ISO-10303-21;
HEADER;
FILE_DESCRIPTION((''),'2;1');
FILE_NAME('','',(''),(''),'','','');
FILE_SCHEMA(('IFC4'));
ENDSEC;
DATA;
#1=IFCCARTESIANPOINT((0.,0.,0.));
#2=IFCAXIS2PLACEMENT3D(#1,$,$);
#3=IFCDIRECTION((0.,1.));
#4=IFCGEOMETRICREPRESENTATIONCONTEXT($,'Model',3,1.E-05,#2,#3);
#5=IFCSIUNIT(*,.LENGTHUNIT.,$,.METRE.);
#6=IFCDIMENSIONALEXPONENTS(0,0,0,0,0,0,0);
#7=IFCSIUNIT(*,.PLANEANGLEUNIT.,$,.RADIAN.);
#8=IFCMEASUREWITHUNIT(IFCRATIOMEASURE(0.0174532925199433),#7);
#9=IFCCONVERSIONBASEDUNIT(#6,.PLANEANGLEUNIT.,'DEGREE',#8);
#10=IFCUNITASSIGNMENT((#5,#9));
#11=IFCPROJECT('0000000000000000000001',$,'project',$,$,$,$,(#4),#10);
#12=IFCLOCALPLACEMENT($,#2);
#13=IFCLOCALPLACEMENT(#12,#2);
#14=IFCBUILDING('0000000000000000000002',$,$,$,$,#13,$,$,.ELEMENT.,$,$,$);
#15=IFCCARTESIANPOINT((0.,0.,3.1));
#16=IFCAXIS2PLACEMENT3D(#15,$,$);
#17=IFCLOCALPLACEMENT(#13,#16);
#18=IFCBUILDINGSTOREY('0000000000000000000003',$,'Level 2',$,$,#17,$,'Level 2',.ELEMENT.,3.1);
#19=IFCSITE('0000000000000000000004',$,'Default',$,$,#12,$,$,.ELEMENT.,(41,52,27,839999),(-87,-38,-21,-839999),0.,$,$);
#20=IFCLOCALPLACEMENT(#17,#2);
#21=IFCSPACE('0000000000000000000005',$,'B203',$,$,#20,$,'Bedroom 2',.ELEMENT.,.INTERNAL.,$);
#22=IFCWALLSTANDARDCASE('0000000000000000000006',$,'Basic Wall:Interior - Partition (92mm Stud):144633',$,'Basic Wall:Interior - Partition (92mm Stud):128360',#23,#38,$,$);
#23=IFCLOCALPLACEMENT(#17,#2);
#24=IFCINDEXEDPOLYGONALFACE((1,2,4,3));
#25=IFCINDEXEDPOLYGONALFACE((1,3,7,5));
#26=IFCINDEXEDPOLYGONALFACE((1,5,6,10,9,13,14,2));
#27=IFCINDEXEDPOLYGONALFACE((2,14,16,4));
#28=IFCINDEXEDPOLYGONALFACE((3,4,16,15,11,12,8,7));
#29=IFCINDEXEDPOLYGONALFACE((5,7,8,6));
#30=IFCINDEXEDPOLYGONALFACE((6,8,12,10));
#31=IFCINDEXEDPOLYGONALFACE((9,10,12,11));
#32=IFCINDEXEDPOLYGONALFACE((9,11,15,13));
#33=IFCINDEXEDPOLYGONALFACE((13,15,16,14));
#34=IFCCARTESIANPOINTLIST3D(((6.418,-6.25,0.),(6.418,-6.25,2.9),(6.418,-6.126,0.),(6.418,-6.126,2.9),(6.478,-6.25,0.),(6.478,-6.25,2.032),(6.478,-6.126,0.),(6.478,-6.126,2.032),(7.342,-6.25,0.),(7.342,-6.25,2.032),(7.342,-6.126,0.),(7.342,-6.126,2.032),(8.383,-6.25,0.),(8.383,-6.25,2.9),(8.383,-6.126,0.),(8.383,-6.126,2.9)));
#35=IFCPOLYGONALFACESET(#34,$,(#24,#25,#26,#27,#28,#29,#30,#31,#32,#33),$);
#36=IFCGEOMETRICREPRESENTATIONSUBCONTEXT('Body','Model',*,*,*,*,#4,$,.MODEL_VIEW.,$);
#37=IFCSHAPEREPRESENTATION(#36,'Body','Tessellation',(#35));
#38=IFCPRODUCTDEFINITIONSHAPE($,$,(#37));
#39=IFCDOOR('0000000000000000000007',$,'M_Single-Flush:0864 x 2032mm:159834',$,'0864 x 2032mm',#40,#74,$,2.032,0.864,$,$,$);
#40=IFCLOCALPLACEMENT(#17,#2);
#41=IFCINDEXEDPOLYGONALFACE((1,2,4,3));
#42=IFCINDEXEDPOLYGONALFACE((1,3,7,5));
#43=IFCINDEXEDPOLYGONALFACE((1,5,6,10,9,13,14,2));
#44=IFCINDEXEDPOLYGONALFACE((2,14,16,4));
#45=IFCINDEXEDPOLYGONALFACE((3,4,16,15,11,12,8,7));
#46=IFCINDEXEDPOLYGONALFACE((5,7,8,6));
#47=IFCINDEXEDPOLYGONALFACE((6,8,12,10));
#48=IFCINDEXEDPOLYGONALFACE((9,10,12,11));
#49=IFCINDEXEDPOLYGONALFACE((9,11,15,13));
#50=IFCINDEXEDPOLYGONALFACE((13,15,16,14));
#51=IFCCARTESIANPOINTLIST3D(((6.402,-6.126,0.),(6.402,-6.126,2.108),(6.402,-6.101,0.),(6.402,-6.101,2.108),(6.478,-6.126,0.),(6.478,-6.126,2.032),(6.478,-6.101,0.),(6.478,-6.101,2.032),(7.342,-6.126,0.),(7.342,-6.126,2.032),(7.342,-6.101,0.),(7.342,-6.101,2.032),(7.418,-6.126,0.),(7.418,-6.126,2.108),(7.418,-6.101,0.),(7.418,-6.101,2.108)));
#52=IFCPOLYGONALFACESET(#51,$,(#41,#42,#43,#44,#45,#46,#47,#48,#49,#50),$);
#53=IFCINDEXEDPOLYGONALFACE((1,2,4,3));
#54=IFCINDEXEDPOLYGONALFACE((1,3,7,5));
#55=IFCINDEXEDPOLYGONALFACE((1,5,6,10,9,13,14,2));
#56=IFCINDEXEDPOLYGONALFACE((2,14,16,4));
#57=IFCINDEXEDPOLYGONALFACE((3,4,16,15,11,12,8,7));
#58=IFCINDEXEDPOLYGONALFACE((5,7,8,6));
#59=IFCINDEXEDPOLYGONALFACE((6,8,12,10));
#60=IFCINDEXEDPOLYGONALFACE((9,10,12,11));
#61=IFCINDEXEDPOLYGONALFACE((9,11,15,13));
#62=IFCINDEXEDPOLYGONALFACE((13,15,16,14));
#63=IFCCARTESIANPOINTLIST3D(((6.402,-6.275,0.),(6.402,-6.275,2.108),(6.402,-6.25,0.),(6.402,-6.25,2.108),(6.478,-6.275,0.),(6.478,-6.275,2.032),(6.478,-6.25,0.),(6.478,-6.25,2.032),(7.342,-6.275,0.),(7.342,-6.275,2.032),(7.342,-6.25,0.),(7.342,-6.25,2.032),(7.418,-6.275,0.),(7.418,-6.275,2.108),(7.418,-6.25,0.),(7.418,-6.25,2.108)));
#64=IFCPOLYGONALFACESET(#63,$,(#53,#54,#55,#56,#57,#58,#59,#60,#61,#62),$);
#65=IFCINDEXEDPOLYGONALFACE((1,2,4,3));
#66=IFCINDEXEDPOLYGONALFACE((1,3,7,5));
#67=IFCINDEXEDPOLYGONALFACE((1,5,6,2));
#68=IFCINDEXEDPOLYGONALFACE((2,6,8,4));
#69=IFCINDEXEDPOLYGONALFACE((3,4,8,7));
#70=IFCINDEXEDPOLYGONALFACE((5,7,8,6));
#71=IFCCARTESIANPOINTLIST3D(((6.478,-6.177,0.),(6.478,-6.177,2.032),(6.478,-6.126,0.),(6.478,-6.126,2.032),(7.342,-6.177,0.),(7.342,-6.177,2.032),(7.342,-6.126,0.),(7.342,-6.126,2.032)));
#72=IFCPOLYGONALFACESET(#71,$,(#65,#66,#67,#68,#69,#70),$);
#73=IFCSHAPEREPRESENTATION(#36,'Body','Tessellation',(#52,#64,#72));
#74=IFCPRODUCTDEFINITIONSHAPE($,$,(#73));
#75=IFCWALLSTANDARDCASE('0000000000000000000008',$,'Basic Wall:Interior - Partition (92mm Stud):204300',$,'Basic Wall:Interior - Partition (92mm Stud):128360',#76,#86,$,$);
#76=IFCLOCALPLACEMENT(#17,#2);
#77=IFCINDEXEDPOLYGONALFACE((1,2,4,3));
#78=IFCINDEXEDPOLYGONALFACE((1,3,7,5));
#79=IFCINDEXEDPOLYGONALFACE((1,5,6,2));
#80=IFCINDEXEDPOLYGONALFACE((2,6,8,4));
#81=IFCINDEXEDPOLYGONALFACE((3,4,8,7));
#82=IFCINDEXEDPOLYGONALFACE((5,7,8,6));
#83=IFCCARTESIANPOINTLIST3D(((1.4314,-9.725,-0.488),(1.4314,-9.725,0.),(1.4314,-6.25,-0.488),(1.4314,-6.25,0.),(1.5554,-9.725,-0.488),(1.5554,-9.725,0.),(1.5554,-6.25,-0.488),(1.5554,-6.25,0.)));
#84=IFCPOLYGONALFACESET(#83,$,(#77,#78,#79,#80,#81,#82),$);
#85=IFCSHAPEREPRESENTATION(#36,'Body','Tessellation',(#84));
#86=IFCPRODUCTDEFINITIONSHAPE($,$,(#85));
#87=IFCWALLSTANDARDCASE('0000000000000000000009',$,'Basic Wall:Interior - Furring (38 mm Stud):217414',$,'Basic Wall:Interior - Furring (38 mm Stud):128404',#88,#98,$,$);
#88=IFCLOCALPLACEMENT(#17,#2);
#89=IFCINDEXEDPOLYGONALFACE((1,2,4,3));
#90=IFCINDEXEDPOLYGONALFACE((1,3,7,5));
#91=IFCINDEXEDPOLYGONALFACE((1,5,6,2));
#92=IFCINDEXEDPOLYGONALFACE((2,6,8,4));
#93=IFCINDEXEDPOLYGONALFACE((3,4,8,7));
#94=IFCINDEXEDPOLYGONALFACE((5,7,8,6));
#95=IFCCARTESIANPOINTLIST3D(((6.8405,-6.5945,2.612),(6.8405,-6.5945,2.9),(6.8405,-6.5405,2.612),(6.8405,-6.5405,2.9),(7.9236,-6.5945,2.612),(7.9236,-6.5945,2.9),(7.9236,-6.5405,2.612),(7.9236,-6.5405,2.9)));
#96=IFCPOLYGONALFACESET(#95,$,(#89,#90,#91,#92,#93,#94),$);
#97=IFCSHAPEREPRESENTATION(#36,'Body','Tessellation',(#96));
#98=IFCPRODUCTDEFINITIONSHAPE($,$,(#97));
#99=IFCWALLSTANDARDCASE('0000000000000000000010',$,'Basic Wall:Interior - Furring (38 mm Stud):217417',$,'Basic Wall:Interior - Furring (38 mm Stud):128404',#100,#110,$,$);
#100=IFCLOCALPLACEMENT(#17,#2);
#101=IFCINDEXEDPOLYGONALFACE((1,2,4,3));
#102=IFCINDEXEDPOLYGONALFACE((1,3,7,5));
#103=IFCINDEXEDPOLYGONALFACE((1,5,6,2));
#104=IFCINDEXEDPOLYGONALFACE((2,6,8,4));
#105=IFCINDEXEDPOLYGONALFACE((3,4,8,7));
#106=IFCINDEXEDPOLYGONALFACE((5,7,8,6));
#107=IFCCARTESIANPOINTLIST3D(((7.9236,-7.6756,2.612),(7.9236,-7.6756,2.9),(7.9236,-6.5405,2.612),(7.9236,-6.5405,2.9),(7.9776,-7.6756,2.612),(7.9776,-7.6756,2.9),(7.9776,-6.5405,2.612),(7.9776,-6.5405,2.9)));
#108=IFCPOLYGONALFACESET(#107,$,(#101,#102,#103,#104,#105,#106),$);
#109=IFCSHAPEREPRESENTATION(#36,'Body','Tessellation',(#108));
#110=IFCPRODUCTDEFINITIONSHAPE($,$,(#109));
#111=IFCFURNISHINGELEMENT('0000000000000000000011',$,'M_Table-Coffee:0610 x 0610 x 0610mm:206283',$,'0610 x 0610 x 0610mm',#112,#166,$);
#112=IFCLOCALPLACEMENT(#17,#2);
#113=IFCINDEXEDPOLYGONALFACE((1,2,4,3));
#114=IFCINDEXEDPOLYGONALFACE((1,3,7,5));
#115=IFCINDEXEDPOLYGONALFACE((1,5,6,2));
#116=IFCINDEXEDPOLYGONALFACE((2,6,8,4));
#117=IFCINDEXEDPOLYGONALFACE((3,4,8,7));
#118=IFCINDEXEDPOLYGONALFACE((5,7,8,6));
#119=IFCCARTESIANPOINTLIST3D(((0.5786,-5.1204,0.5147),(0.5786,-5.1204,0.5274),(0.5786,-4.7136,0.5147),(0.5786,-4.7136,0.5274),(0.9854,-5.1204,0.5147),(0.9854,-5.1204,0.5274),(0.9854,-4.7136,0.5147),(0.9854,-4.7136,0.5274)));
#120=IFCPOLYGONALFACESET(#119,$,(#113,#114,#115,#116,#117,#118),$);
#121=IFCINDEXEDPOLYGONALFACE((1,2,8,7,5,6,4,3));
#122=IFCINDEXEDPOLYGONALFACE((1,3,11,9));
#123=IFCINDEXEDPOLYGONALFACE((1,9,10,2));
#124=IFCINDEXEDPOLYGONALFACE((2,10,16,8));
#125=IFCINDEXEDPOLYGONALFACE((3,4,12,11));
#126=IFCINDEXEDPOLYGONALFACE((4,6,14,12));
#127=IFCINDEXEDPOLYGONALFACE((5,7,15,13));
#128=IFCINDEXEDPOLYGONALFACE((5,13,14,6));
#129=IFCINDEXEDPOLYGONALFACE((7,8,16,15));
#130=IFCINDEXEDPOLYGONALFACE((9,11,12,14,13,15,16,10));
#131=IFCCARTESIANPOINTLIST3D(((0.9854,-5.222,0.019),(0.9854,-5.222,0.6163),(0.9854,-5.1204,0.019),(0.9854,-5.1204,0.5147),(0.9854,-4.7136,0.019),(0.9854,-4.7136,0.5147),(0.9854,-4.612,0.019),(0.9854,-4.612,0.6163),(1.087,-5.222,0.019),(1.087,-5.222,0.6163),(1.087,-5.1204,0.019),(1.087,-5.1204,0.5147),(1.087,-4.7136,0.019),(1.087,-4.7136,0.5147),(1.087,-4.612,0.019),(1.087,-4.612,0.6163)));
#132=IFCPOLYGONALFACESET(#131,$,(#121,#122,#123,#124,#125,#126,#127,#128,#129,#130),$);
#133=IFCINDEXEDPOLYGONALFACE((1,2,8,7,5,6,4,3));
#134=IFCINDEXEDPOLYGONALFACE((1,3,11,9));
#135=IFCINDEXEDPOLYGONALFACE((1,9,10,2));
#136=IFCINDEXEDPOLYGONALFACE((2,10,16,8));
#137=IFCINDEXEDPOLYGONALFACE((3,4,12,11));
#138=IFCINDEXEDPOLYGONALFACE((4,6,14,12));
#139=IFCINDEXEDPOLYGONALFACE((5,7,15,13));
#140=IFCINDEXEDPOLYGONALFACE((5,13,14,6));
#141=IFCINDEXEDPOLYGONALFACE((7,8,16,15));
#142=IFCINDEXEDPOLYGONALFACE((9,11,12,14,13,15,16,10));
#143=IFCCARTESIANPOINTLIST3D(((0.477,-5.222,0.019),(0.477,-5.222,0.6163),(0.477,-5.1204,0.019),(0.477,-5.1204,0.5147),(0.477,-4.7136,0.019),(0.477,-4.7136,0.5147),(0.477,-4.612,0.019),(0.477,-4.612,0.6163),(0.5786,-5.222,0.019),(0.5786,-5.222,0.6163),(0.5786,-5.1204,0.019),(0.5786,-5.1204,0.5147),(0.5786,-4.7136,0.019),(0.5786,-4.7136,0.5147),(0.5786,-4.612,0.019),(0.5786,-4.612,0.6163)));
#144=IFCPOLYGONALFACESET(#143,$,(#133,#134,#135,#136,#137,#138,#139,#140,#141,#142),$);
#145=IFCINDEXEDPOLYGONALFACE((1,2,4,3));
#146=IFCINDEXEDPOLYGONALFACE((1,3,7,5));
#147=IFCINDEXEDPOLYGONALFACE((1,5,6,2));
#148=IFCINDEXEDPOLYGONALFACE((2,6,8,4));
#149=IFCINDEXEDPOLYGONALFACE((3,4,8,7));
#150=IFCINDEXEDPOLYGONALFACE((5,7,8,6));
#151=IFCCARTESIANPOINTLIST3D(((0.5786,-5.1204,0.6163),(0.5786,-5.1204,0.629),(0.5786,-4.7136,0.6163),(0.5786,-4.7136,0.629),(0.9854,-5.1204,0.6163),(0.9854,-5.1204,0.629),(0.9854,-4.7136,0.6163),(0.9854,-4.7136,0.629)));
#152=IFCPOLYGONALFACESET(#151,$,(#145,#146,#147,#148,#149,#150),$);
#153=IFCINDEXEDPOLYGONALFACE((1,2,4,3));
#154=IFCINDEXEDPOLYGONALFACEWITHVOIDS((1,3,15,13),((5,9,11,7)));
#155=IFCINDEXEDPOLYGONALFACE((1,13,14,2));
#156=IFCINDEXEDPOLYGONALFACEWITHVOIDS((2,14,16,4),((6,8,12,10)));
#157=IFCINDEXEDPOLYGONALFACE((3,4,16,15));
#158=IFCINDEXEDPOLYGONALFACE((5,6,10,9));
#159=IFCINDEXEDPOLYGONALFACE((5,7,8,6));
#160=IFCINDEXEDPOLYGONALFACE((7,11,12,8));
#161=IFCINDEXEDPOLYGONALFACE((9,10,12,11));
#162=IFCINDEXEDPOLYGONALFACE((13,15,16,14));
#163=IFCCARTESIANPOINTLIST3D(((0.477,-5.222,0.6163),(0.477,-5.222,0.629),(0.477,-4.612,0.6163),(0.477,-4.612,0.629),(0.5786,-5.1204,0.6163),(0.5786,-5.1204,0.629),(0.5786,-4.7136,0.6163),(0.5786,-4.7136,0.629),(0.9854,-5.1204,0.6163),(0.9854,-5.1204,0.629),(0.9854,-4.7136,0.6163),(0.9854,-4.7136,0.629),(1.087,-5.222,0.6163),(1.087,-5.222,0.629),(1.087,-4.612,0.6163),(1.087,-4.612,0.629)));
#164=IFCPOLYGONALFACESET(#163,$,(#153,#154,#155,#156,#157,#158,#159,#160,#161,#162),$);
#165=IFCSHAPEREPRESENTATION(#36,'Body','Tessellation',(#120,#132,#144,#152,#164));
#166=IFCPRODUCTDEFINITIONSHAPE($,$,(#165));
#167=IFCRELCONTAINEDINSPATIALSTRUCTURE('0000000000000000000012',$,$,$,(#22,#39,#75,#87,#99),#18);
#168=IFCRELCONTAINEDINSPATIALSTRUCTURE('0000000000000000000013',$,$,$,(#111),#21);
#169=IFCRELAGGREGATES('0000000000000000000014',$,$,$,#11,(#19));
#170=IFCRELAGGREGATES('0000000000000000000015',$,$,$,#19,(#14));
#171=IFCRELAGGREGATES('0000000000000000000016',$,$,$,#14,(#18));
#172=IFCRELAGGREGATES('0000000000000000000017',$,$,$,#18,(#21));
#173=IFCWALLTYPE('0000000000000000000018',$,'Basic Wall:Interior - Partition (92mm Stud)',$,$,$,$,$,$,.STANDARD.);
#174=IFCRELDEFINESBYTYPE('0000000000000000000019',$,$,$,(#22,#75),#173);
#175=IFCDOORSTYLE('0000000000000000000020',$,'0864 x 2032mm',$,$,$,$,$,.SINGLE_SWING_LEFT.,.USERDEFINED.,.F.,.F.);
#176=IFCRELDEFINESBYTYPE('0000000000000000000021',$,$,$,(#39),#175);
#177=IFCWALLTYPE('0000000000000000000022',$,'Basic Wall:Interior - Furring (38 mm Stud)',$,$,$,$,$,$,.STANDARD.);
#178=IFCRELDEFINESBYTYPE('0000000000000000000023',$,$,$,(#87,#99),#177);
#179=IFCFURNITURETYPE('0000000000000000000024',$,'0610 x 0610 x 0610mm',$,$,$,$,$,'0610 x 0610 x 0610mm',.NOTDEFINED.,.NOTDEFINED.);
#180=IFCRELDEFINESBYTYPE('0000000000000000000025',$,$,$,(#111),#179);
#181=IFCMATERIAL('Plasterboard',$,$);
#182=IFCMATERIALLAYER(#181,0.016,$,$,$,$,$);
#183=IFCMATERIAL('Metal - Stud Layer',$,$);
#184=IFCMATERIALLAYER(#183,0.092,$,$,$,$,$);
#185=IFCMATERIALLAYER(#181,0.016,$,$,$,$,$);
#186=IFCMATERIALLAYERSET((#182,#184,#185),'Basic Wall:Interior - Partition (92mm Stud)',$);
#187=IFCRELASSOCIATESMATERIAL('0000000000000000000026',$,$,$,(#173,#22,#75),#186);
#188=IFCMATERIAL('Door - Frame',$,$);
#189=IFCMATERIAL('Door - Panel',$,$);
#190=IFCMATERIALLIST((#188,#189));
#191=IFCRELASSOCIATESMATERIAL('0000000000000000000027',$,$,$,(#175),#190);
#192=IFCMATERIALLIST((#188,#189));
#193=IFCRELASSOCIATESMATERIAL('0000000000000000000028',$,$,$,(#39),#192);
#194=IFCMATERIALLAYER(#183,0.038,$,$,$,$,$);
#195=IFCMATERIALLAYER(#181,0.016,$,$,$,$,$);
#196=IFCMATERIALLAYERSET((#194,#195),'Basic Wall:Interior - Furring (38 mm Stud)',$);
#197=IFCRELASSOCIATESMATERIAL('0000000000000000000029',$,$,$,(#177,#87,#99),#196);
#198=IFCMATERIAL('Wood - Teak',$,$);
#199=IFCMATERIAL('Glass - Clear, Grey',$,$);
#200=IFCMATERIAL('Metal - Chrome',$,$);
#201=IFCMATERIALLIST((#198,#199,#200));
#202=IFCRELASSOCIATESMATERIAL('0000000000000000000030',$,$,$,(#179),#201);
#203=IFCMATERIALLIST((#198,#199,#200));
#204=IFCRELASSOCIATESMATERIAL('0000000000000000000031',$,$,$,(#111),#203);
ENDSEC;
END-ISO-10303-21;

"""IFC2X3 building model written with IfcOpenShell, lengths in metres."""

from ifc_helpers import new_model, entity, si_unit, converted_unit, direction, frame, frame_2d, origin, origin_2d_with_axis, place, context, subcontext, project, spatial, polyline, rectangle, outline, extrude, source, transform, mapped, material, material_list, layer, layer_set, layer_usage, type_object, type_shapes, element, fill, save


model = new_model("IFC2X3")

# Units and contexts
model_context = context("Model", 3, precision=1e-05, world=origin(), true_north=direction((0.0, 1.0)))
body_context = subcontext(model_context, "Body", "Model", "MODEL_VIEW")
ifc_project = project(units=[si_unit("LENGTHUNIT", "METRE"), converted_unit("PLANEANGLEUNIT", "DEGREE", entity("IfcRatioMeasure", 0.0174532925199433), si_unit("PLANEANGLEUNIT", "RADIAN"), dimensions=[0, 0, 0, 0, 0, 0, 0])], contexts=[model_context])

# Site, building, storey
site_placement = place(None, origin())
site = spatial("IfcSite", under=ifc_project, at=site_placement, Name="Default", CompositionType="ELEMENT", RefLatitude=(41, 52, 27, 839999), RefLongitude=(-87, -38, -21, -839999), RefElevation=0.0)
building_placement = place(site_placement, origin())
building = spatial("IfcBuilding", under=site, at=building_placement, CompositionType="ELEMENT")
storey_placement = place(building_placement, frame((0.0, 0.0, 3.1)))
storey = spatial("IfcBuildingStorey", under=building, at=storey_placement, Name="Level 2", LongName="Level 2", CompositionType="ELEMENT", Elevation=3.1)

# Shared definitions
ifc_material_1 = material(Name="Metal - Stud Layer")
ifc_material_2 = material(Name="Plasterboard")

# Wall, opening, door
ifc_layer_1 = layer(ifc_material_2, 0.016)
ifc_layer_2 = layer(ifc_material_1, 0.092)
ifc_layer_3 = layer(ifc_material_2, 0.016)
ifc_layer_set_1 = layer_set([ifc_layer_1, ifc_layer_2, ifc_layer_3], Name="Basic Wall:Interior - Partition (92mm Stud)")
wall_type_1 = type_object("IfcWallType", Name="Basic Wall:Interior - Partition (92mm Stud)", PredefinedType="STANDARD", material=ifc_layer_set_1)
ifc_material_3 = material(Name="Door - Frame")
ifc_material_4 = material(Name="Door - Panel")
ifc_layer_usage_1 = layer_usage(ifc_layer_set_1, "AXIS2", "NEGATIVE", 0.062)
wall_1_placement = place(storey_placement, frame((6.418, -6.188, 0.0)))
wall_1 = element("IfcWallStandardCase", 1, at=wall_1_placement, inside=storey, type_object=wall_type_1, material=ifc_layer_usage_1, Name="Basic Wall:Interior - Partition (92mm Stud):144633", ObjectType="Basic Wall:Interior - Partition (92mm Stud):128360", context=body_context, shape_type="SweptSolid", body=[
    extrude(rectangle(XDim=1.965, YDim=0.124, at=frame_2d((0.9825, 0.0), x_axis=(-1.0, 0.0))), origin(), (0.0, 0.0, 1.0), 2.9),
])
opening_1_placement = place(wall_1_placement, frame((0.06, -0.062, 0.0)))
opening_1 = element("IfcOpeningElement", 2, at=opening_1_placement, cuts=wall_1, ObjectType="Opening", context=body_context, shape_type="SweptSolid", body=[
    extrude(rectangle(XDim=0.864, YDim=2.032, at=frame_2d((1.016, 0.432), x_axis=(0.0, -1.0))), frame((0.0, 0.0, 0.0), z_axis=(0.0, 1.0, 0.0), x_axis=(0.0, 0.0, 1.0)), (0.0, 0.0, 1.0), 0.124),
])
ifc_material_list_1 = material_list([ifc_material_3, ifc_material_4])
ifc_material_list_2 = material_list([ifc_material_3, ifc_material_4])
door_style_1 = type_object("IfcDoorStyle", Name="0864 x 2032mm", ConstructionType="USERDEFINED", OperationType="SINGLE_SWING_LEFT", ParameterTakesPrecedence=False, Sizeable=False, material=ifc_material_list_2)
shared_shape_1 = source(origin(), body_context, "Body", "SweptSolid", [
    extrude(outline(polyline([(-0.508, -1.073), (0.508, -1.073), (0.508, 1.035), (0.432, 1.035), (0.432, -0.997), (-0.432, -0.997), (-0.432, 1.035), (-0.508, 1.035), (-0.508, -1.073)])), frame((0.432, 0.149, 1.035), z_axis=(0.0, -1.0, 0.0), x_axis=(-1.0, 0.0, 0.0)), (0.0, 0.0, 1.0), 0.025),
    extrude(outline(polyline([(-1.073, -0.508), (1.035, -0.508), (1.035, -0.432), (-0.997, -0.432), (-0.997, 0.432), (1.035, 0.432), (1.035, 0.508), (-1.073, 0.508), (-1.073, -0.508)])), frame((0.432, 0.0, 1.035), z_axis=(0.0, -1.0, 0.0), x_axis=(0.0, 0.0, -1.0)), (0.0, 0.0, 1.0), 0.025),
    extrude(rectangle(XDim=0.864, YDim=0.051, at=frame_2d((0.0, 0.0), x_axis=(1.0, 0.0))), frame((0.432, 0.0985, 0.0)), (0.0, 0.0, 1.0), 2.032),
])
type_shapes(door_style_1, [shared_shape_1])
door_1_placement = place(opening_1_placement, origin())
door_1 = element("IfcDoor", 3, at=door_1_placement, inside=storey, type_object=door_style_1, material=ifc_material_list_1, Name="M_Single-Flush:0864 x 2032mm:159834", ObjectType="0864 x 2032mm", OverallHeight=2.032, OverallWidth=0.864, context=body_context, shape_type="MappedRepresentation", body=[
    mapped(shared_shape_1, transform((0.0, 0.0, 0.0), scale=1.0)),
])
fill(opening_1, door_1)

# Walls
ifc_layer_usage_2 = layer_usage(ifc_layer_set_1, "AXIS2", "NEGATIVE", 0.062)
wall_2_placement = place(storey_placement, frame((1.4934, -6.25, -0.488), z_axis=(0.0, 0.0, 1.0), x_axis=(0.0, -1.0, 0.0)))
element("IfcWallStandardCase", 4, at=wall_2_placement, inside=storey, type_object=wall_type_1, material=ifc_layer_usage_2, Name="Basic Wall:Interior - Partition (92mm Stud):204300", ObjectType="Basic Wall:Interior - Partition (92mm Stud):128360", context=body_context, shape_type="SweptSolid", body=[
    extrude(rectangle(XDim=3.475, YDim=0.124, at=frame_2d((1.7375, 0.0), x_axis=(-1.0, 0.0))), origin(), (0.0, 0.0, 1.0), 0.488),
])
ifc_layer_4 = layer(ifc_material_1, 0.038)
ifc_layer_5 = layer(ifc_material_2, 0.016)
ifc_layer_set_2 = layer_set([ifc_layer_4, ifc_layer_5], Name="Basic Wall:Interior - Furring (38 mm Stud)")
ifc_layer_usage_3 = layer_usage(ifc_layer_set_2, "AXIS2", "NEGATIVE", 0.027)
wall_type_2 = type_object("IfcWallType", Name="Basic Wall:Interior - Furring (38 mm Stud)", PredefinedType="STANDARD", material=ifc_layer_set_2)
wall_3_placement = place(storey_placement, frame((6.8405, -6.5675, 2.612)))
element("IfcWallStandardCase", 5, at=wall_3_placement, inside=storey, type_object=wall_type_2, material=ifc_layer_usage_3, Name="Basic Wall:Interior - Furring (38 mm Stud):217414", ObjectType="Basic Wall:Interior - Furring (38 mm Stud):128404", context=body_context, shape_type="SweptSolid", body=[
    extrude(rectangle(XDim=1.0831, YDim=0.054, at=frame_2d((0.5415, 0.0), x_axis=(-1.0, 0.0))), origin(), (0.0, 0.0, 1.0), 0.288),
])
ifc_layer_usage_4 = layer_usage(ifc_layer_set_2, "AXIS2", "NEGATIVE", 0.027)
wall_4_placement = place(storey_placement, frame((7.9506, -6.5405, 2.612), z_axis=(0.0, 0.0, 1.0), x_axis=(0.0, -1.0, 0.0)))
element("IfcWallStandardCase", 6, at=wall_4_placement, inside=storey, type_object=wall_type_2, material=ifc_layer_usage_4, Name="Basic Wall:Interior - Furring (38 mm Stud):217417", ObjectType="Basic Wall:Interior - Furring (38 mm Stud):128404", context=body_context, shape_type="SweptSolid", body=[
    extrude(rectangle(XDim=1.1351, YDim=0.054, at=frame_2d((0.5675, 0.0), x_axis=(-1.0, 0.0))), origin(), (0.0, 0.0, 1.0), 0.288),
])

# Shared definitions
space_1_placement = place(storey_placement, origin())
space_1 = spatial("IfcSpace", under=storey, at=space_1_placement, Name="B203", LongName="Bedroom 2", CompositionType="ELEMENT", InteriorOrExteriorSpace="INTERNAL")

# Furnishing element
ifc_material_5 = material(Name="Wood - Teak")
ifc_material_6 = material(Name="Glass - Clear, Grey")
ifc_material_7 = material(Name="Metal - Chrome")
ifc_material_list_3 = material_list([ifc_material_5, ifc_material_6, ifc_material_7])
ifc_material_list_4 = material_list([ifc_material_5, ifc_material_6, ifc_material_7])
furniture_type_1 = type_object("IfcFurnitureType", Name="0610 x 0610 x 0610mm", ElementType="0610 x 0610 x 0610mm", AssemblyPlace="NOTDEFINED", material=ifc_material_list_4)
shared_shape_2 = source(origin(), body_context, "Body", "SweptSolid", [
    extrude(rectangle(XDim=0.4068, YDim=0.4068, at=origin_2d_with_axis()), frame((0.0183, 0.0952, 0.4957), z_axis=(0.0, 0.0, 1.0), x_axis=(-1.0, 0.0, 0.0)), (0.0, 0.0, 1.0), 0.0127),
    extrude(outline(polyline([(-0.2732, -0.305), (0.324, -0.305), (0.324, 0.305), (-0.2732, 0.305), (-0.2732, 0.2034), (0.2225, 0.2034), (0.2225, -0.2034), (-0.2732, -0.2034), (-0.2732, -0.305)])), frame((0.2217, 0.0952, 0.2732), z_axis=(1.0, 0.0, 0.0), x_axis=(0.0, 0.0, 1.0)), (0.0, 0.0, 1.0), 0.1016),
    extrude(outline(polyline([(-0.305, -0.3241), (0.305, -0.3241), (0.305, 0.2733), (0.2034, 0.2733), (0.2034, -0.2224), (-0.2034, -0.2224), (-0.2034, 0.2733), (-0.305, 0.2733), (-0.305, -0.3241)])), frame((-0.2867, 0.0952, 0.2733), z_axis=(1.0, 0.0, 0.0), x_axis=(0.0, -1.0, 0.0)), (0.0, 0.0, 1.0), 0.1016),
    extrude(rectangle(XDim=0.4068, YDim=0.4068, at=origin_2d_with_axis()), frame((0.0183, 0.0952, 0.5973), z_axis=(0.0, 0.0, 1.0), x_axis=(-1.0, 0.0, 0.0)), (0.0, 0.0, 1.0), 0.0127),
    extrude(outline(polyline([(-0.305, -0.305), (0.305, -0.305), (0.305, 0.305), (-0.305, 0.305), (-0.305, -0.305)]), holes=[polyline([(-0.2034, -0.2034), (-0.2034, 0.2034), (0.2034, 0.2034), (0.2034, -0.2034), (-0.2034, -0.2034)])]), frame((0.0183, 0.0952, 0.5973), z_axis=(0.0, 0.0, 1.0), x_axis=(-1.0, 0.0, 0.0)), (0.0, 0.0, 1.0), 0.0127),
])
type_shapes(furniture_type_1, [shared_shape_2])
furnishing_1_placement = place(space_1_placement, frame((0.7637, -5.0122, 0.019)))
element("IfcFurnishingElement", 7, at=furnishing_1_placement, inside=space_1, type_object=furniture_type_1, material=ifc_material_list_3, Name="M_Table-Coffee:0610 x 0610 x 0610mm:206283", ObjectType="0610 x 0610 x 0610mm", context=body_context, shape_type="MappedRepresentation", body=[
    mapped(shared_shape_2, transform((0.0, 0.0, 0.0), scale=1.0)),
])

save(model, "model.ifc")
